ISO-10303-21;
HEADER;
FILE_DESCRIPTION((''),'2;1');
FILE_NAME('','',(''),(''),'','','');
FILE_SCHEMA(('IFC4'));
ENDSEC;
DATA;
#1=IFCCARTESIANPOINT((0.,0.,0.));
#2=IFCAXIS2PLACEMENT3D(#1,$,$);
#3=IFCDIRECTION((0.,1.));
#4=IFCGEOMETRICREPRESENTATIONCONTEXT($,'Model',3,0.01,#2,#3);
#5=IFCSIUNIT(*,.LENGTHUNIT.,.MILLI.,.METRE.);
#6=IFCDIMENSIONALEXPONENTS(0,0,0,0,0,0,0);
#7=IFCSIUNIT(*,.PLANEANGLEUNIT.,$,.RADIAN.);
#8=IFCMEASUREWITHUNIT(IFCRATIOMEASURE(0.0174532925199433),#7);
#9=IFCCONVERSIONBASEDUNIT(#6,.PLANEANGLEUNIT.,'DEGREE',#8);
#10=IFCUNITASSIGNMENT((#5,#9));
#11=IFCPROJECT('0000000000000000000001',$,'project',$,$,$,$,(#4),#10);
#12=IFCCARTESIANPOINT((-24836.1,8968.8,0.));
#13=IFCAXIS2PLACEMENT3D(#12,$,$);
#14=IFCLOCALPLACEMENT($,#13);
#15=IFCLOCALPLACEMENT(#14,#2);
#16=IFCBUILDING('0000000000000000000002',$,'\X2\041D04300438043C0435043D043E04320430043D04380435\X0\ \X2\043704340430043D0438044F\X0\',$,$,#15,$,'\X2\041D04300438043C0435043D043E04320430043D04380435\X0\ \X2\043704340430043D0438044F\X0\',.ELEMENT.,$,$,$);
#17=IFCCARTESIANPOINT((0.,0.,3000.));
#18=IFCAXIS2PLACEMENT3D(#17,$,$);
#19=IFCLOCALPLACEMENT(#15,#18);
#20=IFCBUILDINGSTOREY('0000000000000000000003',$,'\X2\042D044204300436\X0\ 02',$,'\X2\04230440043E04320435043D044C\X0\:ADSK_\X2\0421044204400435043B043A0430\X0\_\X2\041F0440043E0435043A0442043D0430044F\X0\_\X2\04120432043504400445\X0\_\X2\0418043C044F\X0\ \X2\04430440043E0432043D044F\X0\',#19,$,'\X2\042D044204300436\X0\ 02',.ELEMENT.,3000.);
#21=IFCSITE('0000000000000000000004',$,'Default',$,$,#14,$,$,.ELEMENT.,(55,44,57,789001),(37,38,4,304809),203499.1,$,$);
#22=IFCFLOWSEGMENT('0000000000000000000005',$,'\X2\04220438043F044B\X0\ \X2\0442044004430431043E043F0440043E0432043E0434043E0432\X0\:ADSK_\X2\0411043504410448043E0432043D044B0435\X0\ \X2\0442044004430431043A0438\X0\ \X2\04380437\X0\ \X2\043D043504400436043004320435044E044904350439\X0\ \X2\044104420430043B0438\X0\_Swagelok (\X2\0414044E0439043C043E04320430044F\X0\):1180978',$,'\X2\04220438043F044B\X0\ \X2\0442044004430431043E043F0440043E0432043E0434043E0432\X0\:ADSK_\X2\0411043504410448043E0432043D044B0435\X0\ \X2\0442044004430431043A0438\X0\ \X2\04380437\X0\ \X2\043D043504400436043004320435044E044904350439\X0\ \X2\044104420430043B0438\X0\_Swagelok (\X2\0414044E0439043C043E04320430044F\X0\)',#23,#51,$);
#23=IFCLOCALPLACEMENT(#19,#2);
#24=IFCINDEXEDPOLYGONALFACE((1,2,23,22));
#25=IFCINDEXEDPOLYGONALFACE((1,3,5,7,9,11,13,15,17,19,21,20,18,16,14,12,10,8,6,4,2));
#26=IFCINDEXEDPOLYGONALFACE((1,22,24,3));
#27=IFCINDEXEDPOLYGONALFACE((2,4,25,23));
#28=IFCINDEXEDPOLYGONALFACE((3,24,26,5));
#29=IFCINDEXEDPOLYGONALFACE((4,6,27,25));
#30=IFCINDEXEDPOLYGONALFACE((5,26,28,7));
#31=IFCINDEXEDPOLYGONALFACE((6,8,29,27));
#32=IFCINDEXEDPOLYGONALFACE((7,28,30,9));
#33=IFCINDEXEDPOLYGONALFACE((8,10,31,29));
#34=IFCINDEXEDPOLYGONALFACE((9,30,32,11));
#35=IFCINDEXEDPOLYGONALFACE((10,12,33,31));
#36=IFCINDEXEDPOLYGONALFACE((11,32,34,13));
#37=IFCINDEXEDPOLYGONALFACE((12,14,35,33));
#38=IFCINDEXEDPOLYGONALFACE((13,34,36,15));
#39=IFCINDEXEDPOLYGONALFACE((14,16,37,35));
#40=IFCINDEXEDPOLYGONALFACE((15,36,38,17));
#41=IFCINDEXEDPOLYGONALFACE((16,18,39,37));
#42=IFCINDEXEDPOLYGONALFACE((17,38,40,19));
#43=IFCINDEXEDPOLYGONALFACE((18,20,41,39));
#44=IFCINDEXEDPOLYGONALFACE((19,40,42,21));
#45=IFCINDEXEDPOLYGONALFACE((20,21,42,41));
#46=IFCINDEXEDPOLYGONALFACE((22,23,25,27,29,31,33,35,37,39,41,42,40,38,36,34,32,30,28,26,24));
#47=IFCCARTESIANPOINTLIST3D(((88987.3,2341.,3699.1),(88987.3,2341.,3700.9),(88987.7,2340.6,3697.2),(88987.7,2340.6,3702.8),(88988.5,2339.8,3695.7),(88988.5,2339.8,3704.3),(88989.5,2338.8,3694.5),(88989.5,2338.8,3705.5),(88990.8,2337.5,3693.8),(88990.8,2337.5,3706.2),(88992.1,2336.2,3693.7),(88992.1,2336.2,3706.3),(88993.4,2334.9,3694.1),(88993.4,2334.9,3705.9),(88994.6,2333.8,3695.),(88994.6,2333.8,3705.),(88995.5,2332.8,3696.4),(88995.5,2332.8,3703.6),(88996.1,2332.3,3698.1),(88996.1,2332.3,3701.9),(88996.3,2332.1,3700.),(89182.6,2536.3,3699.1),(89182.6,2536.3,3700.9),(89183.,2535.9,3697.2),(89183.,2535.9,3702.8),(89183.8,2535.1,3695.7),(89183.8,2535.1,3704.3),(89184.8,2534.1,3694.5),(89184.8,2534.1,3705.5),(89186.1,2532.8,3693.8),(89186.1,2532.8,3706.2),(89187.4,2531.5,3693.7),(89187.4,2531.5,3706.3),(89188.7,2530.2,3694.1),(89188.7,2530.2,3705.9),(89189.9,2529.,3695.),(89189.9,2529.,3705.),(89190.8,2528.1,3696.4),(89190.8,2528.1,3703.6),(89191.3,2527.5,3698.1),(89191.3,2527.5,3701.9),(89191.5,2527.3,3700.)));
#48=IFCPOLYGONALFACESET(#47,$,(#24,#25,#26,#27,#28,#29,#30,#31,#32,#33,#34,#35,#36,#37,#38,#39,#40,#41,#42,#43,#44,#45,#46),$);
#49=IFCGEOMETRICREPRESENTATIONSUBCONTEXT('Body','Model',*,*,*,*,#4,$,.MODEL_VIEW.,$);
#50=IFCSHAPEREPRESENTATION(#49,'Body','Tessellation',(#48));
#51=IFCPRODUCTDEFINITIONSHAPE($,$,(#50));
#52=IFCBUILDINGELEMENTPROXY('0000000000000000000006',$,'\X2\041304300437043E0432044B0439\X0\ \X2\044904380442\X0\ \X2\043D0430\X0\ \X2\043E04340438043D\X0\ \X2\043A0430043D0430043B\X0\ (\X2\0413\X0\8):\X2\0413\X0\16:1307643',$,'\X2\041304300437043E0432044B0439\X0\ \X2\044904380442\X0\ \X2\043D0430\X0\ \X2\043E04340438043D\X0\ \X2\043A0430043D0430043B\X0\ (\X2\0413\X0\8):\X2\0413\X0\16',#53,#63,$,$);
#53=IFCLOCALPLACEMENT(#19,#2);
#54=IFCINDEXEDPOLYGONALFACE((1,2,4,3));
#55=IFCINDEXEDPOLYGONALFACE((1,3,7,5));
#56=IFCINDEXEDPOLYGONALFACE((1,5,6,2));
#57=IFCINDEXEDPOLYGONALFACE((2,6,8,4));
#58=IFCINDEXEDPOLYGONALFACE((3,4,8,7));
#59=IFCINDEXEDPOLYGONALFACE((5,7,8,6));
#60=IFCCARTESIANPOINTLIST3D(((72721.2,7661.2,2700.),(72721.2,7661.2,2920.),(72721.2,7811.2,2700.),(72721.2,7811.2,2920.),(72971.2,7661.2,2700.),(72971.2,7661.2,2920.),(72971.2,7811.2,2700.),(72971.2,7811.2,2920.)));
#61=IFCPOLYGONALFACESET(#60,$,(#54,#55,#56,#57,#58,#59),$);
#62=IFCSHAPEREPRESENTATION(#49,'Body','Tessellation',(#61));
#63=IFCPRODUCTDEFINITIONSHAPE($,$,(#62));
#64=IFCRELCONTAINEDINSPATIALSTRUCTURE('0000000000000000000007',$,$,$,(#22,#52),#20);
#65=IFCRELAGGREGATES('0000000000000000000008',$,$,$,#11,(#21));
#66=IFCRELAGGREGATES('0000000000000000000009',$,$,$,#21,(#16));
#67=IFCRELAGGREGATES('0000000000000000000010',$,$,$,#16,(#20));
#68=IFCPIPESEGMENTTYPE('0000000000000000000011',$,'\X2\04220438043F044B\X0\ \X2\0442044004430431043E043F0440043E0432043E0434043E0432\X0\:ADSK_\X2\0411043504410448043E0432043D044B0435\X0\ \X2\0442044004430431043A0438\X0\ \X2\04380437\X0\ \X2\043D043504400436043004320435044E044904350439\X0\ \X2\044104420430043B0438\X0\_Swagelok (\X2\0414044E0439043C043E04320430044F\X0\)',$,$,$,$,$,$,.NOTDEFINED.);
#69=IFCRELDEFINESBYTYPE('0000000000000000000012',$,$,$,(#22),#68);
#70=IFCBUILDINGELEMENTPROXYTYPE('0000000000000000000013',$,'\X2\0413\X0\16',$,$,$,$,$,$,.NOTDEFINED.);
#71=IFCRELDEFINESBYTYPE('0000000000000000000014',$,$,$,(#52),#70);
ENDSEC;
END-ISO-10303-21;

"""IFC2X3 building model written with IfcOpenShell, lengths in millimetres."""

from ifc_helpers import new_model, entity, si_unit, converted_unit, direction, frame, origin, origin_2d_with_axis, place, context, subcontext, project, spatial, rectangle, circle, extrude, type_object, element, save


model = new_model("IFC2X3")

# Units and contexts
model_context = context("Model", 3, precision=0.01, world=origin(), true_north=direction((0.0, 1.0)))
body_context = subcontext(model_context, "Body", "Model", "MODEL_VIEW")
ifc_project = project(units=[si_unit("LENGTHUNIT", "METRE", prefix="MILLI"), converted_unit("PLANEANGLEUNIT", "DEGREE", entity("IfcRatioMeasure", 0.0174532925199433), si_unit("PLANEANGLEUNIT", "RADIAN"), dimensions=[0, 0, 0, 0, 0, 0, 0])], contexts=[model_context])

# Site, building, storey
site_placement = place(None, frame((-24836.1, 8968.8, 0.0)))
site = spatial("IfcSite", under=ifc_project, at=site_placement, Name="Default", CompositionType="ELEMENT", RefLatitude=(55, 44, 57, 789001), RefLongitude=(37, 38, 4, 304809), RefElevation=203499.1)
building_placement = place(site_placement, origin())
building = spatial("IfcBuilding", under=site, at=building_placement, Name="Наименование здания", LongName="Наименование здания", CompositionType="ELEMENT")
storey_placement = place(building_placement, frame((0.0, 0.0, 3000.0)))
storey = spatial("IfcBuildingStorey", under=building, at=storey_placement, Name="Этаж 02", ObjectType="Уровень:ADSK_Стрелка_Проектная_Вверх_Имя уровня", LongName="Этаж 02", CompositionType="ELEMENT", Elevation=3000.0)

# Flow segment
pipe_segment_type_1 = type_object("IfcPipeSegmentType", Name="Типы трубопроводов:ADSK_Бесшовные трубки из нержавеющей стали_Swagelok (Дюймовая)", PredefinedType="NOTDEFINED")
flow_segment_1_placement = place(storey_placement, frame((88985.7, 2330.5, 3692.1)))
element("IfcFlowSegment", 1, at=flow_segment_1_placement, inside=storey, type_object=pipe_segment_type_1, Name="Типы трубопроводов:ADSK_Бесшовные трубки из нержавеющей стали_Swagelok (Дюймовая):1180978", ObjectType="Типы трубопроводов:ADSK_Бесшовные трубки из нержавеющей стали_Swagelok (Дюймовая)", context=body_context, shape_type="SweptSolid", body=[
    extrude(circle(Radius=6.3, at=origin_2d_with_axis()), frame((6.1, 6.1, 8.0), z_axis=(0.707107, 0.707107, 0.0), x_axis=(0.707107, -0.707107, 0.0)), (0.0, 0.0, 1.0), 276.2),
])

# Building element proxy
building_element_proxy_type_1 = type_object("IfcBuildingElementProxyType", Name="Г16", PredefinedType="NOTDEFINED")
proxy_1_placement = place(storey_placement, frame((72721.2, 7661.2, 2700.0)))
element("IfcBuildingElementProxy", 2, at=proxy_1_placement, inside=storey, type_object=building_element_proxy_type_1, Name="Газовый щит на один канал (Г8):Г16:1307643", ObjectType="Газовый щит на один канал (Г8):Г16", context=body_context, shape_type="SweptSolid", body=[
    extrude(rectangle(XDim=250.0, YDim=150.0, at=origin_2d_with_axis()), frame((125.0, 75.0, 0.0), z_axis=(0.0, 0.0, 1.0), x_axis=(-1.0, 0.0, 0.0)), (0.0, 0.0, 1.0), 220.0),
])

save(model, "model.ifc")
